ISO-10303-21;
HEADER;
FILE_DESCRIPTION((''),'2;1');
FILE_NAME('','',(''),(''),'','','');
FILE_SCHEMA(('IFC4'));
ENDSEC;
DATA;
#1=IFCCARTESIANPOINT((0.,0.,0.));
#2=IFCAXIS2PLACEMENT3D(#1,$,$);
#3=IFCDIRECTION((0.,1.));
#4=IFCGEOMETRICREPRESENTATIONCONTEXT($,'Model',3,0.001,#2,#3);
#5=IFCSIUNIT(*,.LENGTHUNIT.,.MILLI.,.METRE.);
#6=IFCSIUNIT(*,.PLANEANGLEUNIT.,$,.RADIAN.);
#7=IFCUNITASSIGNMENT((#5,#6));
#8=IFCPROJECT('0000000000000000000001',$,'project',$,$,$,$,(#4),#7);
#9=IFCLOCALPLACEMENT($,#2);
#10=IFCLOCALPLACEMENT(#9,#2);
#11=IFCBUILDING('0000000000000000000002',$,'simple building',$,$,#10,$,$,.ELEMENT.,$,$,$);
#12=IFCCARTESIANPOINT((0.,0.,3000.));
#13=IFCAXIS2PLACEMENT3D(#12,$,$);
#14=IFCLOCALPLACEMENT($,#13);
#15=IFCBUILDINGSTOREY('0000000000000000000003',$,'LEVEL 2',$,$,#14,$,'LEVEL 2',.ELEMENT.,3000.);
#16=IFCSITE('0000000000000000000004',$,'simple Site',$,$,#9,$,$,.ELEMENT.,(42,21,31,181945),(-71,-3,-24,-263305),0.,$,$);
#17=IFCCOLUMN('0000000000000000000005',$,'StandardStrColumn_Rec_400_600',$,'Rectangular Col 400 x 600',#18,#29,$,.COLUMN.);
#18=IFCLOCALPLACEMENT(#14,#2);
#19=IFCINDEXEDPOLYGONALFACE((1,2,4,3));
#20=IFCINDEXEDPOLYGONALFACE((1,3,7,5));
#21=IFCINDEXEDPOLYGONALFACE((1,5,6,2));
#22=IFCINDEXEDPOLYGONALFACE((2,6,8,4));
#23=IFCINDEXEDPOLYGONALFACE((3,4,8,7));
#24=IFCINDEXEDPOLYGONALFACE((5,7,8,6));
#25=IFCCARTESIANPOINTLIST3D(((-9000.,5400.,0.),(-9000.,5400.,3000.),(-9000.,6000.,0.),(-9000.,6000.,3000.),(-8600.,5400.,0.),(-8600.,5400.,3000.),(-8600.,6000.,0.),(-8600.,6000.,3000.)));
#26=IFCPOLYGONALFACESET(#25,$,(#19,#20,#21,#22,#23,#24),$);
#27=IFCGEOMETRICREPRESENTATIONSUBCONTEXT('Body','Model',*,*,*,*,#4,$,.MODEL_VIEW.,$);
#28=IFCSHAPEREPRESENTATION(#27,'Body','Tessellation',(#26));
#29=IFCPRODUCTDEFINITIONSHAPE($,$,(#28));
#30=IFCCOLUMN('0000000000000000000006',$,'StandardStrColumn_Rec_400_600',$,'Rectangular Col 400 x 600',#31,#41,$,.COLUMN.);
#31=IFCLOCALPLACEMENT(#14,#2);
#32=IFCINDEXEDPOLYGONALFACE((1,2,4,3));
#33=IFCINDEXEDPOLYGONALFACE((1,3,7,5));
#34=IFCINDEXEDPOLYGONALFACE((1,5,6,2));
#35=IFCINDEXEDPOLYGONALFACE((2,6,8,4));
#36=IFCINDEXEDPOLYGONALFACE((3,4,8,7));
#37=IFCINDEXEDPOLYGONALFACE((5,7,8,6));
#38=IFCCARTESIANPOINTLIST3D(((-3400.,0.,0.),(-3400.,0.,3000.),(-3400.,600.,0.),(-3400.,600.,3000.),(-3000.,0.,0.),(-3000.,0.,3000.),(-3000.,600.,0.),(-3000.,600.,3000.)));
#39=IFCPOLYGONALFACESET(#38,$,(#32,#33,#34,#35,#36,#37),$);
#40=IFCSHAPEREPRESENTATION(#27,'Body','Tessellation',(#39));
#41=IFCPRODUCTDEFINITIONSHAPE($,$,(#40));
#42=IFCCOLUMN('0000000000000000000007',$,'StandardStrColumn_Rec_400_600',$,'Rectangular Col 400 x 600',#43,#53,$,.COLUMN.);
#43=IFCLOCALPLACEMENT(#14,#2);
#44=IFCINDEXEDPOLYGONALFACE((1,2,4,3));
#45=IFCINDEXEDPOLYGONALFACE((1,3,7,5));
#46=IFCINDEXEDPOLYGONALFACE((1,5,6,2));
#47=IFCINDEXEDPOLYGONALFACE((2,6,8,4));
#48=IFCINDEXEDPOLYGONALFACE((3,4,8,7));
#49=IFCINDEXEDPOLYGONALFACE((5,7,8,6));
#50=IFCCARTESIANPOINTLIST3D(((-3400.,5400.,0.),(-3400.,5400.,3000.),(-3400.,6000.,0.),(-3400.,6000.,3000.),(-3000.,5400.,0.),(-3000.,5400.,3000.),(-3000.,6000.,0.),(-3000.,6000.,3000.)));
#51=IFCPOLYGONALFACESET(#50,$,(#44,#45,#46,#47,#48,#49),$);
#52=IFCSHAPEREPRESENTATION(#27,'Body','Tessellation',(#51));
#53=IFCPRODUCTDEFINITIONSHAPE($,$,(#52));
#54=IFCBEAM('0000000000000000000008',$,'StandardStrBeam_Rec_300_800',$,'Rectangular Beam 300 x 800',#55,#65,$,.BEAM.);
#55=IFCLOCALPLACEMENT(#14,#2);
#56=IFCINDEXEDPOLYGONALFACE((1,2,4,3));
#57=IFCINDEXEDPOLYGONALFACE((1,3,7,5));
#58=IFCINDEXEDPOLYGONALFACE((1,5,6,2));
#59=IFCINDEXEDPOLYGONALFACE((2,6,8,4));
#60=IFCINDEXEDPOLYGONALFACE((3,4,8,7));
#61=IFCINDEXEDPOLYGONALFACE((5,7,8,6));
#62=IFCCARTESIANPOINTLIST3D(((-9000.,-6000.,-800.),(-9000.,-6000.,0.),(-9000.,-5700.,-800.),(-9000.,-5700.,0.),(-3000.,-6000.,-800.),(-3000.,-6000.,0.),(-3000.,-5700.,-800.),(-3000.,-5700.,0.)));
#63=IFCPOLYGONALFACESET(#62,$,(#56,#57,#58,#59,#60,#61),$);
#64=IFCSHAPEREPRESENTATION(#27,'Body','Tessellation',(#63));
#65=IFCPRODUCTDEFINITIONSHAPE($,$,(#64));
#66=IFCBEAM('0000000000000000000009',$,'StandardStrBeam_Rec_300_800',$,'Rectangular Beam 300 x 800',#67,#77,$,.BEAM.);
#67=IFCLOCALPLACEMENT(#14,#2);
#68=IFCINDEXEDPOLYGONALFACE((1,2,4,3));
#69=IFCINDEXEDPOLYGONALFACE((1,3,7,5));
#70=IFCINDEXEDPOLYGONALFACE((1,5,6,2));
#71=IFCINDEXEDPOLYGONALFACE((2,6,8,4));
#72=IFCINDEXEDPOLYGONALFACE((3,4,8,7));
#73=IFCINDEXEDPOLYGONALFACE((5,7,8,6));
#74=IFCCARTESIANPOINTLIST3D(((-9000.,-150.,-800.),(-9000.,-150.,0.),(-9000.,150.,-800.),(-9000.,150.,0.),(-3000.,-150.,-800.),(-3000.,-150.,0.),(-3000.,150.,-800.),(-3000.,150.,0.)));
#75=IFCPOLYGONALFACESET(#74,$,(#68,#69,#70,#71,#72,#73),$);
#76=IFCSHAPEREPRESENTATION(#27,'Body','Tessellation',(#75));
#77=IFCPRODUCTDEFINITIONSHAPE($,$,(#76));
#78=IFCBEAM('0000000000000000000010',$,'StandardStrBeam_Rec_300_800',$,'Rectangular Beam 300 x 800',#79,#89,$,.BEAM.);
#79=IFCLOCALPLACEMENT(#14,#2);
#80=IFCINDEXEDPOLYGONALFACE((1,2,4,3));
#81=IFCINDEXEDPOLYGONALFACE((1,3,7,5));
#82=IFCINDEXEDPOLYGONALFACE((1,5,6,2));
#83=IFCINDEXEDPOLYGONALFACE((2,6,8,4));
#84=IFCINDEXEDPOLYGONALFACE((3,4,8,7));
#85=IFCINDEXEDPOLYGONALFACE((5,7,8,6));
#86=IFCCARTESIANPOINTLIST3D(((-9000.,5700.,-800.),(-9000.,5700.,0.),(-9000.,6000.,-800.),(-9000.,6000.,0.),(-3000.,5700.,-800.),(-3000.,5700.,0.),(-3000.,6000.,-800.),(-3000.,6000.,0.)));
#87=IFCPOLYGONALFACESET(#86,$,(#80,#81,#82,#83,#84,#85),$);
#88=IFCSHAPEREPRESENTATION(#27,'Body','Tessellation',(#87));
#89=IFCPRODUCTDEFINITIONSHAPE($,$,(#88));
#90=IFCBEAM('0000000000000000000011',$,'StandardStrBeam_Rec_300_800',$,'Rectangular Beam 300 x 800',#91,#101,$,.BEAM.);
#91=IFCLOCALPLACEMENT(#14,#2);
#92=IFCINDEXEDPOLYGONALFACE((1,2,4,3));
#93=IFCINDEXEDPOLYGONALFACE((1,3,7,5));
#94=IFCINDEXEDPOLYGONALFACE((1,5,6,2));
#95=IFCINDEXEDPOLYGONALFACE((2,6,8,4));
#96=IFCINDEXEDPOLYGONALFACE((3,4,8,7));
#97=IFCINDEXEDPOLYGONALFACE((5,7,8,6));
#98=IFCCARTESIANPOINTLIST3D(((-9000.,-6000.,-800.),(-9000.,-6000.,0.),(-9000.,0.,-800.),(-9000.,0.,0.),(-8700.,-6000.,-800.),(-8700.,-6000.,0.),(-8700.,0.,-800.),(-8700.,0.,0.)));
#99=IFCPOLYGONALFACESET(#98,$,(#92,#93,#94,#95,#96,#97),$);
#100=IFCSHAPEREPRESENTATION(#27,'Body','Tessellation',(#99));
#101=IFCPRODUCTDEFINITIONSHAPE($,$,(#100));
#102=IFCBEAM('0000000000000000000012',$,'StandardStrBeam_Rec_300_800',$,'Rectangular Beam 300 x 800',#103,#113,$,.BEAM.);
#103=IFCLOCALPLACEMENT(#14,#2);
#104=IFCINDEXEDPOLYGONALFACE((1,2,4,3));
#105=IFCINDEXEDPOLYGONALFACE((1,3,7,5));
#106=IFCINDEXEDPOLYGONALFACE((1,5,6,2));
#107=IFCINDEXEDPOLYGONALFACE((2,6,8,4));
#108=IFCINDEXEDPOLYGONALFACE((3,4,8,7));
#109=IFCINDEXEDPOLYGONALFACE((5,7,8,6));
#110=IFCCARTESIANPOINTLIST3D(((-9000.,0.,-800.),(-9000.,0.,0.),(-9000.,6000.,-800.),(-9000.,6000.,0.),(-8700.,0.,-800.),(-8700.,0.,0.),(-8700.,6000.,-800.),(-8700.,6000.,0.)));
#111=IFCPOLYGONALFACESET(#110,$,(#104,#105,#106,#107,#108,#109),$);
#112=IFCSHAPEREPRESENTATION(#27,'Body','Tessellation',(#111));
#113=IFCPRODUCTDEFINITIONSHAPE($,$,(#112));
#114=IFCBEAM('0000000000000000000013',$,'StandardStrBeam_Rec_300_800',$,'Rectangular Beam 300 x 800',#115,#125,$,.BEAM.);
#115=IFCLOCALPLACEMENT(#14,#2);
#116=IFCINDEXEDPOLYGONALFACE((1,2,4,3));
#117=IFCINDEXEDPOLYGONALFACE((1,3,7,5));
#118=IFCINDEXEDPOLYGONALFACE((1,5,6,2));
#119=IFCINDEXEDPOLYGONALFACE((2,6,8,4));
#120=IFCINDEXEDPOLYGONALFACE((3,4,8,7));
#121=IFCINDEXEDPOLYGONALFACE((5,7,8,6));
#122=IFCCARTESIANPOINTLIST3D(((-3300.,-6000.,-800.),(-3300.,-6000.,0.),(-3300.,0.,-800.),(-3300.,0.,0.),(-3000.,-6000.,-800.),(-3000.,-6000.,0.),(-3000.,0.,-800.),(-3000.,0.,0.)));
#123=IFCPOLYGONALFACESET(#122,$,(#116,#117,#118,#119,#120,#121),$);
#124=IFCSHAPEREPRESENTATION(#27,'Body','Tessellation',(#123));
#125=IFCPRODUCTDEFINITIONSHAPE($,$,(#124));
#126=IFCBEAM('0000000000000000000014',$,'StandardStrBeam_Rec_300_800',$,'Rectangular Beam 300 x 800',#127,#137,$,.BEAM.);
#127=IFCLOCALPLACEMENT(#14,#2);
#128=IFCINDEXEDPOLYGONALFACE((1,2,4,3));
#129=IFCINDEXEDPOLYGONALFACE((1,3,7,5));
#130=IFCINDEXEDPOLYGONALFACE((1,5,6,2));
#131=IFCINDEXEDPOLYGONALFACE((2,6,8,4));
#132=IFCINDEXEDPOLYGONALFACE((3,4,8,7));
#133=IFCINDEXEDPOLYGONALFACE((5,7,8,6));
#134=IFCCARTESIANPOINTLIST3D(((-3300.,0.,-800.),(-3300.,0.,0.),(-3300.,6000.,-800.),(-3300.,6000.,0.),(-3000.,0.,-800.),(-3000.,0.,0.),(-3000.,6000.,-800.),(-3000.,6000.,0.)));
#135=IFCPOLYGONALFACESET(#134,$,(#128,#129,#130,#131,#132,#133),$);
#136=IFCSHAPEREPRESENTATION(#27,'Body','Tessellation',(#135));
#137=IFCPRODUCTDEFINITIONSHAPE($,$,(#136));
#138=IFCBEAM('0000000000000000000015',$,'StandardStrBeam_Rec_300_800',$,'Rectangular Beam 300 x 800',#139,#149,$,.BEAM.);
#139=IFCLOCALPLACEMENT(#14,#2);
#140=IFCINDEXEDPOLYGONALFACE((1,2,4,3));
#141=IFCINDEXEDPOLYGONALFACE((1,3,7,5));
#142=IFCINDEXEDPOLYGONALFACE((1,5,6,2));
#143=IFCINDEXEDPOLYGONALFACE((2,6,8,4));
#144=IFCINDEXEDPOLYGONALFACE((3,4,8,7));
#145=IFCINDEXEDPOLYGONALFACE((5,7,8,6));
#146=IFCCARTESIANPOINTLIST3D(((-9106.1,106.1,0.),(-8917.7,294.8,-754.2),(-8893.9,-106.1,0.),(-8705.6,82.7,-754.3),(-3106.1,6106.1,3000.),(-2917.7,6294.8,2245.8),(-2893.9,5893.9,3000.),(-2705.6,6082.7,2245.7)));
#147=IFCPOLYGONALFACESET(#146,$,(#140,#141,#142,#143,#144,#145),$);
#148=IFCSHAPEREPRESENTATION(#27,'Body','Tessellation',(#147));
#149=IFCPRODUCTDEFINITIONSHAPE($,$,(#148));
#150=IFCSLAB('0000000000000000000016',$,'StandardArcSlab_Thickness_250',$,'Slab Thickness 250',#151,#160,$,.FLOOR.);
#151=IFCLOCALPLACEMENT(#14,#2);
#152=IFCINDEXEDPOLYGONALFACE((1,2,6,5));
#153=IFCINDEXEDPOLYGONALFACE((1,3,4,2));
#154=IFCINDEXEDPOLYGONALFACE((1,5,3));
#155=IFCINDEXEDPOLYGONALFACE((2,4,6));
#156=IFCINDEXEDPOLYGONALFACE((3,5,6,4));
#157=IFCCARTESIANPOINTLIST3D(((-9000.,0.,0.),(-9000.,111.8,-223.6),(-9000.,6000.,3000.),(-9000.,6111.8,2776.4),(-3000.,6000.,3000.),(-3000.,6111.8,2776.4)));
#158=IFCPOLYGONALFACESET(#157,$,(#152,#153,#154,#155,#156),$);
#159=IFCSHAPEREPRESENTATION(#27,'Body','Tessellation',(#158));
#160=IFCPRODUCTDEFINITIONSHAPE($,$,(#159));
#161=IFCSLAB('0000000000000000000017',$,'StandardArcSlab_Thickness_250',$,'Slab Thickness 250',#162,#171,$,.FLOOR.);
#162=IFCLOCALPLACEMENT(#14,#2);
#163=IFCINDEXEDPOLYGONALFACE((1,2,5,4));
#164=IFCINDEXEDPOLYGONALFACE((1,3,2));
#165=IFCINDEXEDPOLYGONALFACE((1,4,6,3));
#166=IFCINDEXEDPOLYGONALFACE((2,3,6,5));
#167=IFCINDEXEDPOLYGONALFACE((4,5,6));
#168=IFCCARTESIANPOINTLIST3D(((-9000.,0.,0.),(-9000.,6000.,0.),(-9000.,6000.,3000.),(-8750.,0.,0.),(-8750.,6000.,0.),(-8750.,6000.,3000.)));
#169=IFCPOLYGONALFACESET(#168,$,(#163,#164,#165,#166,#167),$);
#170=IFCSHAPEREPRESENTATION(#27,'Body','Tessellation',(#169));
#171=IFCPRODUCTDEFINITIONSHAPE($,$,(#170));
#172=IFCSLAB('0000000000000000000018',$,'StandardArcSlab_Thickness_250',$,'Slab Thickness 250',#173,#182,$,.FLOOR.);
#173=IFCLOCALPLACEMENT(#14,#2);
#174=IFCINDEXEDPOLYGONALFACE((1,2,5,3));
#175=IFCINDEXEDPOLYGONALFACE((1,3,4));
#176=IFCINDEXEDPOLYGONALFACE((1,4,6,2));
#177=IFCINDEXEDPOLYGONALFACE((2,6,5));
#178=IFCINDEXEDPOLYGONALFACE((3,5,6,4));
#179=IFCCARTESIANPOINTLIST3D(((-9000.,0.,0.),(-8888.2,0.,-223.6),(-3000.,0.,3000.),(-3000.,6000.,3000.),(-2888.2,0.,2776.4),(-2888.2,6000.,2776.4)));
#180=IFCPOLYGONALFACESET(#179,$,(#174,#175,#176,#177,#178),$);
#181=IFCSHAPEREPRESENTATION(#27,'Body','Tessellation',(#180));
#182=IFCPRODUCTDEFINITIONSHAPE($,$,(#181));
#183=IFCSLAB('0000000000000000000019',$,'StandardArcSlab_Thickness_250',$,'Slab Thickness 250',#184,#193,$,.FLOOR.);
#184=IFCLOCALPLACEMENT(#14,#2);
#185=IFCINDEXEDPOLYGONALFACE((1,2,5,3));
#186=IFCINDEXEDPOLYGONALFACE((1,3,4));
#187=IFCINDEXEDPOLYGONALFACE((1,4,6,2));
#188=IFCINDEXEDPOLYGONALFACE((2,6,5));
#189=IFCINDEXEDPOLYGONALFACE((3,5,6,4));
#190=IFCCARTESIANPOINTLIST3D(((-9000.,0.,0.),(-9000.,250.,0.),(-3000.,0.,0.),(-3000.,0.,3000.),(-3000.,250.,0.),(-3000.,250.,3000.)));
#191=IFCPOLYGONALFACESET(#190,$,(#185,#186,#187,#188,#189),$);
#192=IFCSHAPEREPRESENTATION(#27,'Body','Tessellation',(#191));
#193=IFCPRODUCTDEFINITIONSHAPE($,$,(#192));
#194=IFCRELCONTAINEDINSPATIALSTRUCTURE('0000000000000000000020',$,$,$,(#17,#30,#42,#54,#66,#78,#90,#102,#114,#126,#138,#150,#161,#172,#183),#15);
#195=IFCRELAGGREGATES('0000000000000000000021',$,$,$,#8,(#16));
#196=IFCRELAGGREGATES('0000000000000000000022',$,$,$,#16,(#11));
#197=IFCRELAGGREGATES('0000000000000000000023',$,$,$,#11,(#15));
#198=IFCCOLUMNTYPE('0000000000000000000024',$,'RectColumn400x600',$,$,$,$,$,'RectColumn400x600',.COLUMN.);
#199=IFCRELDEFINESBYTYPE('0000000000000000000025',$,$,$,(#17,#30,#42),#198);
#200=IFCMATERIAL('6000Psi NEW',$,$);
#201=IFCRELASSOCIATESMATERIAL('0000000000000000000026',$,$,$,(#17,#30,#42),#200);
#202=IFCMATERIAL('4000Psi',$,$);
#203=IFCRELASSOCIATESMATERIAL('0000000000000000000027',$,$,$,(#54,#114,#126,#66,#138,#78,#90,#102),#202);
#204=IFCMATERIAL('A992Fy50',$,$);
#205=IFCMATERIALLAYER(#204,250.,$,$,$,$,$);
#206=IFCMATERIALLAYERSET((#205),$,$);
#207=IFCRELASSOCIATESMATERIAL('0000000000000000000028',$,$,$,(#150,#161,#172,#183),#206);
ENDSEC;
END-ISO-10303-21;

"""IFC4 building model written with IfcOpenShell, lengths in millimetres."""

from ifc_helpers import new_model, si_unit, direction, frame, origin, origin_with_axes, origin_2d_with_axis, place, context, subcontext, project, spatial, polyline, rectangle, outline, extrude, material, layer, layer_set, layer_usage, material_profile, profile_set, profile_usage, type_object, element, save


model = new_model("IFC4")

# Units and contexts
model_context = context("Model", 3, precision=0.001, world=origin(), true_north=direction((0.0, 1.0)))
body_context = subcontext(model_context, "Body", "Model", "MODEL_VIEW")
ifc_project = project(units=[si_unit("LENGTHUNIT", "METRE", prefix="MILLI"), si_unit("PLANEANGLEUNIT", "RADIAN")], contexts=[model_context])

# Site, building, storey
site_placement = place(None, origin())
site = spatial("IfcSite", under=ifc_project, at=site_placement, Name="simple Site", CompositionType="ELEMENT", RefLatitude=(42, 21, 31, 181945), RefLongitude=(-71, -3, -24, -263305), RefElevation=0.0)
building_placement = place(site_placement, origin())
building = spatial("IfcBuilding", under=site, at=building_placement, Name="simple building", CompositionType="ELEMENT")
storey_placement = place(None, frame((0.0, 0.0, 3000.0)))
storey = spatial("IfcBuildingStorey", under=building, at=storey_placement, Name="LEVEL 2", LongName="LEVEL 2", CompositionType="ELEMENT", Elevation=3000.0)

# Columns
ifc_material_1 = material(Name="6000Psi NEW")
ifc_material_profile_1 = material_profile(ifc_material_1, rectangle(XDim=400.0, YDim=600.0, at=origin_2d_with_axis()))
ifc_profile_set_1 = profile_set([ifc_material_profile_1])
ifc_profile_usage_1 = profile_usage(ifc_profile_set_1, cardinal=1)
column_type = type_object("IfcColumnType", Name="RectColumn400x600", ElementType="RectColumn400x600", PredefinedType="COLUMN")
column_1_placement = place(None, frame((-8800.0, 5700.0, 3000.0), z_axis=(0.0, 0.0, 1.0), x_axis=(1.0, 0.0, 0.0)))
element("IfcColumn", 1, at=column_1_placement, inside=storey, type_object=column_type, material=ifc_profile_usage_1, Name="StandardStrColumn_Rec_400_600", ObjectType="Rectangular Col 400 x 600", PredefinedType="COLUMN", context=body_context, shape_type="SweptSolid", body=[
    extrude(rectangle(XDim=400.0, YDim=600.0, at=origin_2d_with_axis()), origin_with_axes(), (0.0, 0.0, 1.0), 3000.0),
])
ifc_profile_usage_2 = profile_usage(ifc_profile_set_1, cardinal=9)
column_2_placement = place(None, frame((-3200.0, 300.0, 3000.0), z_axis=(0.0, 0.0, 1.0), x_axis=(1.0, 0.0, 0.0)))
element("IfcColumn", 2, at=column_2_placement, inside=storey, type_object=column_type, material=ifc_profile_usage_2, Name="StandardStrColumn_Rec_400_600", ObjectType="Rectangular Col 400 x 600", PredefinedType="COLUMN", context=body_context, shape_type="SweptSolid", body=[
    extrude(rectangle(XDim=400.0, YDim=600.0, at=origin_2d_with_axis()), origin_with_axes(), (0.0, 0.0, 1.0), 3000.0),
])
ifc_profile_usage_3 = profile_usage(ifc_profile_set_1, cardinal=3)
column_3_placement = place(None, frame((-3200.0, 5700.0, 3000.0), z_axis=(0.0, 0.0, 1.0), x_axis=(1.0, 0.0, 0.0)))
element("IfcColumn", 3, at=column_3_placement, inside=storey, type_object=column_type, material=ifc_profile_usage_3, Name="StandardStrColumn_Rec_400_600", ObjectType="Rectangular Col 400 x 600", PredefinedType="COLUMN", context=body_context, shape_type="SweptSolid", body=[
    extrude(rectangle(XDim=400.0, YDim=600.0, at=origin_2d_with_axis()), origin_with_axes(), (0.0, 0.0, 1.0), 3000.0),
])

# Beams
ifc_material_2 = material(Name="4000Psi")
ifc_material_profile_2 = material_profile(ifc_material_2, rectangle(XDim=300.0, YDim=800.0, at=origin_2d_with_axis()))
ifc_profile_set_2 = profile_set([ifc_material_profile_2])
ifc_profile_usage_4 = profile_usage(ifc_profile_set_2, cardinal=9)
beam_1_placement = place(None, frame((-9000.0, -5850.0, 2600.0), z_axis=(1.0, 0.0, 0.0), x_axis=(0.0, -1.0, 0.0)))
element("IfcBeam", 4, at=beam_1_placement, inside=storey, material=ifc_profile_usage_4, Name="StandardStrBeam_Rec_300_800", ObjectType="Rectangular Beam 300 x 800", PredefinedType="BEAM", context=body_context, shape_type="SweptSolid", body=[
    extrude(rectangle(XDim=300.0, YDim=800.0, at=origin_2d_with_axis()), origin_with_axes(), (0.0, 0.0, 1.0), 6000.0),
])
ifc_profile_usage_5 = profile_usage(ifc_profile_set_2, cardinal=8)
beam_2_placement = place(None, frame((-9000.0, 0.0, 2600.0), z_axis=(1.0, 0.0, 0.0), x_axis=(0.0, -1.0, 0.0)))
element("IfcBeam", 5, at=beam_2_placement, inside=storey, material=ifc_profile_usage_5, Name="StandardStrBeam_Rec_300_800", ObjectType="Rectangular Beam 300 x 800", PredefinedType="BEAM", context=body_context, shape_type="SweptSolid", body=[
    extrude(rectangle(XDim=300.0, YDim=800.0, at=origin_2d_with_axis()), origin_with_axes(), (0.0, 0.0, 1.0), 6000.0),
])
ifc_profile_usage_6 = profile_usage(ifc_profile_set_2, cardinal=7)
for number, where, z_axis, x_axis, name in (
    (6, (-9000.0, 5850.0, 2600.0), (1.0, 0.0, 0.0), (0.0, -1.0, 0.0), "StandardStrBeam_Rec_300_800"),
    (7, (-8850.0, -6000.0, 2600.0), (0.0, 1.0, 0.0), (1.0, 0.0, 0.0), "StandardStrBeam_Rec_300_800"),
    (8, (-8850.0, 0.0, 2600.0), (0.0, 1.0, 0.0), (1.0, 0.0, 0.0), "StandardStrBeam_Rec_300_800"),
):
    element("IfcBeam", number, at=place(None, frame(where, z_axis=z_axis, x_axis=x_axis)), inside=storey, material=ifc_profile_usage_6, Name=name, ObjectType="Rectangular Beam 300 x 800", PredefinedType="BEAM", context=body_context, shape_type="SweptSolid", body=[
        extrude(rectangle(XDim=300.0, YDim=800.0, at=origin_2d_with_axis()), origin_with_axes(), (0.0, 0.0, 1.0), 6000.0),
    ])
for number, where, z_axis, x_axis, name in (
    (9, (-3150.0, -6000.0, 2600.0), (0.0, 1.0, 0.0), (1.0, 0.0, 0.0), "StandardStrBeam_Rec_300_800"),
    (10, (-3150.0, 0.0, 2600.0), (0.0, 1.0, 0.0), (1.0, 0.0, 0.0), "StandardStrBeam_Rec_300_800"),
):
    element("IfcBeam", number, at=place(None, frame(where, z_axis=z_axis, x_axis=x_axis)), inside=storey, material=ifc_profile_usage_4, Name=name, ObjectType="Rectangular Beam 300 x 800", PredefinedType="BEAM", context=body_context, shape_type="SweptSolid", body=[
        extrude(rectangle(XDim=300.0, YDim=800.0, at=origin_2d_with_axis()), origin_with_axes(), (0.0, 0.0, 1.0), 6000.0),
    ])
beam_3_placement = place(None, frame((-8905.8, 94.4, 2622.9), z_axis=(0.666667, 0.666667, 0.333333), x_axis=(0.707189, -0.707025, -0.000329)))
element("IfcBeam", 11, at=beam_3_placement, inside=storey, material=ifc_profile_usage_5, Name="StandardStrBeam_Rec_300_800", ObjectType="Rectangular Beam 300 x 800", PredefinedType="BEAM", context=body_context, shape_type="SweptSolid", body=[
    extrude(rectangle(XDim=300.0, YDim=800.0, at=origin_2d_with_axis()), origin_with_axes(), (0.0, 0.0, 1.0), 9000.0),
])

# Slabs
ifc_material_3 = material(Name="A992Fy50")
ifc_layer = layer(ifc_material_3, 250.0)
ifc_layer_set = layer_set([ifc_layer])
ifc_layer_usage = layer_usage(ifc_layer_set, "AXIS3", "POSITIVE", -250.0)
slab_1_placement = place(None, frame((-9000.0, 6111.8, 5776.4), z_axis=(0.0, -0.447214, 0.894427), x_axis=(0.0, -0.894427, -0.447214)))
element("IfcSlab", 12, at=slab_1_placement, inside=storey, material=ifc_layer_usage, Name="StandardArcSlab_Thickness_250", ObjectType="Slab Thickness 250", PredefinedType="FLOOR", context=body_context, shape_type="SweptSolid", body=[
    extrude(outline(polyline([(0.0, 0.0), (6708.2, 0.0), (0.0, 6000.0), (0.0, 0.0)])), origin_with_axes(), (0.0, 0.0, 1.0), 250.0),
])
slab_2_placement = place(None, frame((-8750.0, 6000.0, 3000.0), z_axis=(-1.0, 0.0, 0.0), x_axis=(0.0, -1.0, 0.0)))
element("IfcSlab", 13, at=slab_2_placement, inside=storey, material=ifc_layer_usage, Name="StandardArcSlab_Thickness_250", ObjectType="Slab Thickness 250", PredefinedType="FLOOR", context=body_context, shape_type="SweptSolid", body=[
    extrude(outline(polyline([(0.0, 0.0), (6000.0, 0.0), (0.0, 3000.0), (0.0, 0.0)])), origin_with_axes(), (0.0, 0.0, 1.0), 250.0),
])
slab_3_placement = place(None, frame((-8888.2, 0.0, 2776.4), z_axis=(-0.447214, 0.0, 0.894427), x_axis=(0.894427, 0.0, 0.447214)))
element("IfcSlab", 14, at=slab_3_placement, inside=storey, material=ifc_layer_usage, Name="StandardArcSlab_Thickness_250", ObjectType="Slab Thickness 250", PredefinedType="FLOOR", context=body_context, shape_type="SweptSolid", body=[
    extrude(outline(polyline([(0.0, 0.0), (6708.2, 0.0), (6708.2, 6000.0), (0.0, 0.0)])), origin_with_axes(), (0.0, 0.0, 1.0), 250.0),
])
slab_4_placement = place(None, frame((-9000.0, 250.0, 3000.0), z_axis=(0.0, -1.0, 0.0), x_axis=(1.0, 0.0, 0.0)))
element("IfcSlab", 15, at=slab_4_placement, inside=storey, material=ifc_layer_usage, Name="StandardArcSlab_Thickness_250", ObjectType="Slab Thickness 250", PredefinedType="FLOOR", context=body_context, shape_type="SweptSolid", body=[
    extrude(outline(polyline([(0.0, 0.0), (6000.0, 0.0), (6000.0, 3000.0), (0.0, 0.0)])), origin_with_axes(), (0.0, 0.0, 1.0), 250.0),
])

save(model, "model.ifc")
